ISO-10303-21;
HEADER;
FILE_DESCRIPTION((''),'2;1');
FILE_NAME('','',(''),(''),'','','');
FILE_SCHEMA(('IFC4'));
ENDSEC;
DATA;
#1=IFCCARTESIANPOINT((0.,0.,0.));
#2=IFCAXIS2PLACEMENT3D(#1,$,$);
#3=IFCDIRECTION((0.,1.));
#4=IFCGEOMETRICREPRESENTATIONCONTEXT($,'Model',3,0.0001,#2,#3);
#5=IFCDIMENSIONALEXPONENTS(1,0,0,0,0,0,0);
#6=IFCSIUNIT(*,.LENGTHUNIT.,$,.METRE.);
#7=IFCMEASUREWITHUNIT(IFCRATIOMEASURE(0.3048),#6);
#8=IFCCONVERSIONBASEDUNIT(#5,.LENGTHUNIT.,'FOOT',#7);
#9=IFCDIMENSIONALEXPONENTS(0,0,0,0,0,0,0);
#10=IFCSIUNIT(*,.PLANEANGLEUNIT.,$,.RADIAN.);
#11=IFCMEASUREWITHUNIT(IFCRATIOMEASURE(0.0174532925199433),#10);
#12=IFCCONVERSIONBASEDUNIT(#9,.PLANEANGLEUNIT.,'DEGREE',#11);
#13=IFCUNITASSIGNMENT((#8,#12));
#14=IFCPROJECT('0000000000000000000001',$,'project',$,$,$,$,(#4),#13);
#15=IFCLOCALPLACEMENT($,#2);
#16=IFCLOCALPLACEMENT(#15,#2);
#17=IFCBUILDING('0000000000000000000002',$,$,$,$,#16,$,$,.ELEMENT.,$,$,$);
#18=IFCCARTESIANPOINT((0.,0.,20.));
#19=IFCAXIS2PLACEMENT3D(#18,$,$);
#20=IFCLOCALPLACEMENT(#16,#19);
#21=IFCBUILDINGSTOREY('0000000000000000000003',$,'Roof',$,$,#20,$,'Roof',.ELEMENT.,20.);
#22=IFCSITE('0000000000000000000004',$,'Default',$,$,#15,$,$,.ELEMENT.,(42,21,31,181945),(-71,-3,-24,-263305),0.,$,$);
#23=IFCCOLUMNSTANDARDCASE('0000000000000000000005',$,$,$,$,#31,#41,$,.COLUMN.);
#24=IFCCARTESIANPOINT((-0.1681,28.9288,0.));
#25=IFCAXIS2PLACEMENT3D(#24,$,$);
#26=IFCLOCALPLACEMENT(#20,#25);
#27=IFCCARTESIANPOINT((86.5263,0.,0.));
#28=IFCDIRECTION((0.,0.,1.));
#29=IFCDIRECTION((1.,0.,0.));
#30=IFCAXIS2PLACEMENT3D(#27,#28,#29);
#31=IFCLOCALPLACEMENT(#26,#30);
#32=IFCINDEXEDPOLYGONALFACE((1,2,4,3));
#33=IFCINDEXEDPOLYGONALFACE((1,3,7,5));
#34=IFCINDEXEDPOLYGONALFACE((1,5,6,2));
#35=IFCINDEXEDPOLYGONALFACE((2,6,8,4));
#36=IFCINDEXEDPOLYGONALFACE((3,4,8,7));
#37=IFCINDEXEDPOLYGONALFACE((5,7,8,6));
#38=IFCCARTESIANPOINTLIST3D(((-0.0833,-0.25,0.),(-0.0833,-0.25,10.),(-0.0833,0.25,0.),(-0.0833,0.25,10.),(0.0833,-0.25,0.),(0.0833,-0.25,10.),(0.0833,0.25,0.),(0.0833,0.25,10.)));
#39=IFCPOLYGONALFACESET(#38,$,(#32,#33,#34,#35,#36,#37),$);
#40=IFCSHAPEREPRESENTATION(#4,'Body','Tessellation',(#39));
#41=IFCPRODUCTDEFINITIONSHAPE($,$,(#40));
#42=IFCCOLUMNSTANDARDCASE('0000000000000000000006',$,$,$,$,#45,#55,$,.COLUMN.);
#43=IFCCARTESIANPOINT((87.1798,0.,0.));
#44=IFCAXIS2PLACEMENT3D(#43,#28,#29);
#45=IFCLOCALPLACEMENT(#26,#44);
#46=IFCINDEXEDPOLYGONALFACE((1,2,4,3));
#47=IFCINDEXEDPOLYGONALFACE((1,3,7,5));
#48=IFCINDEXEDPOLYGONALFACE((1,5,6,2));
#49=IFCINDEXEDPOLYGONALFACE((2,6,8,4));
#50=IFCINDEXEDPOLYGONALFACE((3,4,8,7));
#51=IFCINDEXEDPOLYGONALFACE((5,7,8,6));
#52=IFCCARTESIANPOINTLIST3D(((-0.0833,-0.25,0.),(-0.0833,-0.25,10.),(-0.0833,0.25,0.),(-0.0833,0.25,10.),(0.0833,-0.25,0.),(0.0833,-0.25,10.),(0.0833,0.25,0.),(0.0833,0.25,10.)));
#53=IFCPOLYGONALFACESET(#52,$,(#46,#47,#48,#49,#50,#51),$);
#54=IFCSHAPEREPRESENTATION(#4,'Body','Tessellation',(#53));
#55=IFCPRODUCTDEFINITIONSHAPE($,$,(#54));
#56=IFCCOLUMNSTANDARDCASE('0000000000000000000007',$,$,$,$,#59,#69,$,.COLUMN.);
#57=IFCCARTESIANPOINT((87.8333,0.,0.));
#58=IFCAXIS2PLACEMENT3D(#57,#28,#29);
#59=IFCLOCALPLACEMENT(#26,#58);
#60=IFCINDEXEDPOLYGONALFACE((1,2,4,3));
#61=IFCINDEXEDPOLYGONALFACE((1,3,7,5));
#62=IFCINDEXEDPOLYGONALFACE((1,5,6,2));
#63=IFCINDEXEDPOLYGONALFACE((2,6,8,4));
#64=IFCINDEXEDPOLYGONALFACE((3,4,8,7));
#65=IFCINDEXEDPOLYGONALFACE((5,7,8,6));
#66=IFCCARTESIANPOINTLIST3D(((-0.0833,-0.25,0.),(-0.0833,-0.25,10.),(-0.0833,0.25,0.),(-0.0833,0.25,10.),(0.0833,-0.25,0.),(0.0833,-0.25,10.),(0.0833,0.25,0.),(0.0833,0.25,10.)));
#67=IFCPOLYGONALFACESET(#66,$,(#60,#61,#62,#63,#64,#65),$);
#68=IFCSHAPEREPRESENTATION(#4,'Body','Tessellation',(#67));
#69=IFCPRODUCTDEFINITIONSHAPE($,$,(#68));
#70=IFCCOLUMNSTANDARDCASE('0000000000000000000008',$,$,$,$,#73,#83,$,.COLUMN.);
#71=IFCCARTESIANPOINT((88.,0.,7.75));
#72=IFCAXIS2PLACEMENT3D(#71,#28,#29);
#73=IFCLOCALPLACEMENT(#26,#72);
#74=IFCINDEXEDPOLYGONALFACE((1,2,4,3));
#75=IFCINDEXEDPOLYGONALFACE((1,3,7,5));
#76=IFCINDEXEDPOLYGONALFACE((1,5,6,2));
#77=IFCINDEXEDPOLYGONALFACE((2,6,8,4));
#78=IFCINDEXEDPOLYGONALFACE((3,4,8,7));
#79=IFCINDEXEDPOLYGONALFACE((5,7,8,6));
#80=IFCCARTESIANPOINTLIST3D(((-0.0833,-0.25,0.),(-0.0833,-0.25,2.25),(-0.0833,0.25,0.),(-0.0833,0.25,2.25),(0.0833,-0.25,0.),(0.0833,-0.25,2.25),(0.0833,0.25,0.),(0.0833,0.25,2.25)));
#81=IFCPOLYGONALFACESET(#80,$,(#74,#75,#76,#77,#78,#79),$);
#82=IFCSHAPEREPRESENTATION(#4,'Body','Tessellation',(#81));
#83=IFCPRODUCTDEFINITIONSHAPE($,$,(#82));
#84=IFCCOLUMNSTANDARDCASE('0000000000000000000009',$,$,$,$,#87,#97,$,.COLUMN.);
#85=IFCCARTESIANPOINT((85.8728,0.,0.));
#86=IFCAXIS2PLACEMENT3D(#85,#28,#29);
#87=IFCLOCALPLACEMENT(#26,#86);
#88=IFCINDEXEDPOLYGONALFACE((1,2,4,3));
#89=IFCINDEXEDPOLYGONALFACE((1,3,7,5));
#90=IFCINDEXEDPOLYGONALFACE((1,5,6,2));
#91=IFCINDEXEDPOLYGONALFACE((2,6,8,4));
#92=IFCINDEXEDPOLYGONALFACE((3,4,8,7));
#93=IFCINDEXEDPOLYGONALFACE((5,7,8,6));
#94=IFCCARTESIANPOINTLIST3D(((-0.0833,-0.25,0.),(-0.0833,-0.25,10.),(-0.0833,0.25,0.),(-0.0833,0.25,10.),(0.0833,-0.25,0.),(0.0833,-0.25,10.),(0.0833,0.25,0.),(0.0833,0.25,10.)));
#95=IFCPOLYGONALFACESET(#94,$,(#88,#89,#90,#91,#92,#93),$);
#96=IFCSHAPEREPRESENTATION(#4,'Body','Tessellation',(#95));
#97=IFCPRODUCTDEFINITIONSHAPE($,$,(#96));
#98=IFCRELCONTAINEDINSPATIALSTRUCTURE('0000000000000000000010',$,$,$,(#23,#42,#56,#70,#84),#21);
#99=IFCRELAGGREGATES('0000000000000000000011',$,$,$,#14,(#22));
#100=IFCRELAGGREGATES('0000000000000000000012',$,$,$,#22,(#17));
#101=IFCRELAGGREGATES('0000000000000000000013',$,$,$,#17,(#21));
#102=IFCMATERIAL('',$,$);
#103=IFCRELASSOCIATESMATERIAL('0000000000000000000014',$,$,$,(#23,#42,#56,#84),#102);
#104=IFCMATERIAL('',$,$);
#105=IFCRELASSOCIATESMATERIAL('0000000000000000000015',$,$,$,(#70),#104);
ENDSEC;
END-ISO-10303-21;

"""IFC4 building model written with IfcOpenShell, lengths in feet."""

from ifc_helpers import new_model, entity, si_unit, converted_unit, direction, frame, origin, place, context, project, spatial, rectangle, extrude, material, element, save


model = new_model("IFC4")

# Units and contexts
model_context = context("Model", 3, precision=0.0001, world=origin(), true_north=direction((0.0, 1.0)))
ifc_project = project(units=[converted_unit("LENGTHUNIT", "FOOT", entity("IfcRatioMeasure", 0.3048), si_unit("LENGTHUNIT", "METRE"), dimensions=[1, 0, 0, 0, 0, 0, 0]), converted_unit("PLANEANGLEUNIT", "DEGREE", entity("IfcRatioMeasure", 0.0174532925199433), si_unit("PLANEANGLEUNIT", "RADIAN"), dimensions=[0, 0, 0, 0, 0, 0, 0])], contexts=[model_context])

# Site, building, storey
site_placement = place(None, origin())
site = spatial("IfcSite", under=ifc_project, at=site_placement, Name="Default", CompositionType="ELEMENT", RefLatitude=(42, 21, 31, 181945), RefLongitude=(-71, -3, -24, -263305), RefElevation=0.0)
building_placement = place(site_placement, origin())
building = spatial("IfcBuilding", under=site, at=building_placement, CompositionType="ELEMENT")
storey_placement = place(building_placement, frame((0.0, 0.0, 20.0)))
storey = spatial("IfcBuildingStorey", under=building, at=storey_placement, Name="Roof", LongName="Roof", CompositionType="ELEMENT", Elevation=20.0)

# Columns
ifc_material_1 = material(Name="")
placement = place(storey_placement, frame((-0.1681, 28.9288, 0.0)))
for number, where, z_axis, x_axis in (
    (1, (86.5263, 0.0, 0.0), (0.0, 0.0, 1.0), (1.0, 0.0, 0.0)),
    (2, (87.1798, 0.0, 0.0), (0.0, 0.0, 1.0), (1.0, 0.0, 0.0)),
    (3, (87.8333, 0.0, 0.0), (0.0, 0.0, 1.0), (1.0, 0.0, 0.0)),
):
    element("IfcColumnStandardCase", number, at=place(placement, frame(where, z_axis=z_axis, x_axis=x_axis)), inside=storey, material=ifc_material_1, PredefinedType="COLUMN", context=model_context, shape_type="SweptSolid", body=[
        extrude(rectangle(XDim=0.1667, YDim=0.5), origin(), (0.0, 0.0, 1.0), 10.0),
    ])
ifc_material_2 = material(Name="")
for number, where, z_axis, x_axis in (
    (4, (88.0, 0.0, 7.75), (0.0, 0.0, 1.0), (1.0, 0.0, 0.0)),
):
    element("IfcColumnStandardCase", number, at=place(placement, frame(where, z_axis=z_axis, x_axis=x_axis)), inside=storey, material=ifc_material_2, PredefinedType="COLUMN", context=model_context, shape_type="SweptSolid", body=[
        extrude(rectangle(XDim=0.1667, YDim=0.5), origin(), (0.0, 0.0, 1.0), 2.25),
    ])
for number, where, z_axis, x_axis in (
    (5, (85.8728, 0.0, 0.0), (0.0, 0.0, 1.0), (1.0, 0.0, 0.0)),
):
    element("IfcColumnStandardCase", number, at=place(placement, frame(where, z_axis=z_axis, x_axis=x_axis)), inside=storey, material=ifc_material_1, PredefinedType="COLUMN", context=model_context, shape_type="SweptSolid", body=[
        extrude(rectangle(XDim=0.1667, YDim=0.5), origin(), (0.0, 0.0, 1.0), 10.0),
    ])

save(model, "model.ifc")
